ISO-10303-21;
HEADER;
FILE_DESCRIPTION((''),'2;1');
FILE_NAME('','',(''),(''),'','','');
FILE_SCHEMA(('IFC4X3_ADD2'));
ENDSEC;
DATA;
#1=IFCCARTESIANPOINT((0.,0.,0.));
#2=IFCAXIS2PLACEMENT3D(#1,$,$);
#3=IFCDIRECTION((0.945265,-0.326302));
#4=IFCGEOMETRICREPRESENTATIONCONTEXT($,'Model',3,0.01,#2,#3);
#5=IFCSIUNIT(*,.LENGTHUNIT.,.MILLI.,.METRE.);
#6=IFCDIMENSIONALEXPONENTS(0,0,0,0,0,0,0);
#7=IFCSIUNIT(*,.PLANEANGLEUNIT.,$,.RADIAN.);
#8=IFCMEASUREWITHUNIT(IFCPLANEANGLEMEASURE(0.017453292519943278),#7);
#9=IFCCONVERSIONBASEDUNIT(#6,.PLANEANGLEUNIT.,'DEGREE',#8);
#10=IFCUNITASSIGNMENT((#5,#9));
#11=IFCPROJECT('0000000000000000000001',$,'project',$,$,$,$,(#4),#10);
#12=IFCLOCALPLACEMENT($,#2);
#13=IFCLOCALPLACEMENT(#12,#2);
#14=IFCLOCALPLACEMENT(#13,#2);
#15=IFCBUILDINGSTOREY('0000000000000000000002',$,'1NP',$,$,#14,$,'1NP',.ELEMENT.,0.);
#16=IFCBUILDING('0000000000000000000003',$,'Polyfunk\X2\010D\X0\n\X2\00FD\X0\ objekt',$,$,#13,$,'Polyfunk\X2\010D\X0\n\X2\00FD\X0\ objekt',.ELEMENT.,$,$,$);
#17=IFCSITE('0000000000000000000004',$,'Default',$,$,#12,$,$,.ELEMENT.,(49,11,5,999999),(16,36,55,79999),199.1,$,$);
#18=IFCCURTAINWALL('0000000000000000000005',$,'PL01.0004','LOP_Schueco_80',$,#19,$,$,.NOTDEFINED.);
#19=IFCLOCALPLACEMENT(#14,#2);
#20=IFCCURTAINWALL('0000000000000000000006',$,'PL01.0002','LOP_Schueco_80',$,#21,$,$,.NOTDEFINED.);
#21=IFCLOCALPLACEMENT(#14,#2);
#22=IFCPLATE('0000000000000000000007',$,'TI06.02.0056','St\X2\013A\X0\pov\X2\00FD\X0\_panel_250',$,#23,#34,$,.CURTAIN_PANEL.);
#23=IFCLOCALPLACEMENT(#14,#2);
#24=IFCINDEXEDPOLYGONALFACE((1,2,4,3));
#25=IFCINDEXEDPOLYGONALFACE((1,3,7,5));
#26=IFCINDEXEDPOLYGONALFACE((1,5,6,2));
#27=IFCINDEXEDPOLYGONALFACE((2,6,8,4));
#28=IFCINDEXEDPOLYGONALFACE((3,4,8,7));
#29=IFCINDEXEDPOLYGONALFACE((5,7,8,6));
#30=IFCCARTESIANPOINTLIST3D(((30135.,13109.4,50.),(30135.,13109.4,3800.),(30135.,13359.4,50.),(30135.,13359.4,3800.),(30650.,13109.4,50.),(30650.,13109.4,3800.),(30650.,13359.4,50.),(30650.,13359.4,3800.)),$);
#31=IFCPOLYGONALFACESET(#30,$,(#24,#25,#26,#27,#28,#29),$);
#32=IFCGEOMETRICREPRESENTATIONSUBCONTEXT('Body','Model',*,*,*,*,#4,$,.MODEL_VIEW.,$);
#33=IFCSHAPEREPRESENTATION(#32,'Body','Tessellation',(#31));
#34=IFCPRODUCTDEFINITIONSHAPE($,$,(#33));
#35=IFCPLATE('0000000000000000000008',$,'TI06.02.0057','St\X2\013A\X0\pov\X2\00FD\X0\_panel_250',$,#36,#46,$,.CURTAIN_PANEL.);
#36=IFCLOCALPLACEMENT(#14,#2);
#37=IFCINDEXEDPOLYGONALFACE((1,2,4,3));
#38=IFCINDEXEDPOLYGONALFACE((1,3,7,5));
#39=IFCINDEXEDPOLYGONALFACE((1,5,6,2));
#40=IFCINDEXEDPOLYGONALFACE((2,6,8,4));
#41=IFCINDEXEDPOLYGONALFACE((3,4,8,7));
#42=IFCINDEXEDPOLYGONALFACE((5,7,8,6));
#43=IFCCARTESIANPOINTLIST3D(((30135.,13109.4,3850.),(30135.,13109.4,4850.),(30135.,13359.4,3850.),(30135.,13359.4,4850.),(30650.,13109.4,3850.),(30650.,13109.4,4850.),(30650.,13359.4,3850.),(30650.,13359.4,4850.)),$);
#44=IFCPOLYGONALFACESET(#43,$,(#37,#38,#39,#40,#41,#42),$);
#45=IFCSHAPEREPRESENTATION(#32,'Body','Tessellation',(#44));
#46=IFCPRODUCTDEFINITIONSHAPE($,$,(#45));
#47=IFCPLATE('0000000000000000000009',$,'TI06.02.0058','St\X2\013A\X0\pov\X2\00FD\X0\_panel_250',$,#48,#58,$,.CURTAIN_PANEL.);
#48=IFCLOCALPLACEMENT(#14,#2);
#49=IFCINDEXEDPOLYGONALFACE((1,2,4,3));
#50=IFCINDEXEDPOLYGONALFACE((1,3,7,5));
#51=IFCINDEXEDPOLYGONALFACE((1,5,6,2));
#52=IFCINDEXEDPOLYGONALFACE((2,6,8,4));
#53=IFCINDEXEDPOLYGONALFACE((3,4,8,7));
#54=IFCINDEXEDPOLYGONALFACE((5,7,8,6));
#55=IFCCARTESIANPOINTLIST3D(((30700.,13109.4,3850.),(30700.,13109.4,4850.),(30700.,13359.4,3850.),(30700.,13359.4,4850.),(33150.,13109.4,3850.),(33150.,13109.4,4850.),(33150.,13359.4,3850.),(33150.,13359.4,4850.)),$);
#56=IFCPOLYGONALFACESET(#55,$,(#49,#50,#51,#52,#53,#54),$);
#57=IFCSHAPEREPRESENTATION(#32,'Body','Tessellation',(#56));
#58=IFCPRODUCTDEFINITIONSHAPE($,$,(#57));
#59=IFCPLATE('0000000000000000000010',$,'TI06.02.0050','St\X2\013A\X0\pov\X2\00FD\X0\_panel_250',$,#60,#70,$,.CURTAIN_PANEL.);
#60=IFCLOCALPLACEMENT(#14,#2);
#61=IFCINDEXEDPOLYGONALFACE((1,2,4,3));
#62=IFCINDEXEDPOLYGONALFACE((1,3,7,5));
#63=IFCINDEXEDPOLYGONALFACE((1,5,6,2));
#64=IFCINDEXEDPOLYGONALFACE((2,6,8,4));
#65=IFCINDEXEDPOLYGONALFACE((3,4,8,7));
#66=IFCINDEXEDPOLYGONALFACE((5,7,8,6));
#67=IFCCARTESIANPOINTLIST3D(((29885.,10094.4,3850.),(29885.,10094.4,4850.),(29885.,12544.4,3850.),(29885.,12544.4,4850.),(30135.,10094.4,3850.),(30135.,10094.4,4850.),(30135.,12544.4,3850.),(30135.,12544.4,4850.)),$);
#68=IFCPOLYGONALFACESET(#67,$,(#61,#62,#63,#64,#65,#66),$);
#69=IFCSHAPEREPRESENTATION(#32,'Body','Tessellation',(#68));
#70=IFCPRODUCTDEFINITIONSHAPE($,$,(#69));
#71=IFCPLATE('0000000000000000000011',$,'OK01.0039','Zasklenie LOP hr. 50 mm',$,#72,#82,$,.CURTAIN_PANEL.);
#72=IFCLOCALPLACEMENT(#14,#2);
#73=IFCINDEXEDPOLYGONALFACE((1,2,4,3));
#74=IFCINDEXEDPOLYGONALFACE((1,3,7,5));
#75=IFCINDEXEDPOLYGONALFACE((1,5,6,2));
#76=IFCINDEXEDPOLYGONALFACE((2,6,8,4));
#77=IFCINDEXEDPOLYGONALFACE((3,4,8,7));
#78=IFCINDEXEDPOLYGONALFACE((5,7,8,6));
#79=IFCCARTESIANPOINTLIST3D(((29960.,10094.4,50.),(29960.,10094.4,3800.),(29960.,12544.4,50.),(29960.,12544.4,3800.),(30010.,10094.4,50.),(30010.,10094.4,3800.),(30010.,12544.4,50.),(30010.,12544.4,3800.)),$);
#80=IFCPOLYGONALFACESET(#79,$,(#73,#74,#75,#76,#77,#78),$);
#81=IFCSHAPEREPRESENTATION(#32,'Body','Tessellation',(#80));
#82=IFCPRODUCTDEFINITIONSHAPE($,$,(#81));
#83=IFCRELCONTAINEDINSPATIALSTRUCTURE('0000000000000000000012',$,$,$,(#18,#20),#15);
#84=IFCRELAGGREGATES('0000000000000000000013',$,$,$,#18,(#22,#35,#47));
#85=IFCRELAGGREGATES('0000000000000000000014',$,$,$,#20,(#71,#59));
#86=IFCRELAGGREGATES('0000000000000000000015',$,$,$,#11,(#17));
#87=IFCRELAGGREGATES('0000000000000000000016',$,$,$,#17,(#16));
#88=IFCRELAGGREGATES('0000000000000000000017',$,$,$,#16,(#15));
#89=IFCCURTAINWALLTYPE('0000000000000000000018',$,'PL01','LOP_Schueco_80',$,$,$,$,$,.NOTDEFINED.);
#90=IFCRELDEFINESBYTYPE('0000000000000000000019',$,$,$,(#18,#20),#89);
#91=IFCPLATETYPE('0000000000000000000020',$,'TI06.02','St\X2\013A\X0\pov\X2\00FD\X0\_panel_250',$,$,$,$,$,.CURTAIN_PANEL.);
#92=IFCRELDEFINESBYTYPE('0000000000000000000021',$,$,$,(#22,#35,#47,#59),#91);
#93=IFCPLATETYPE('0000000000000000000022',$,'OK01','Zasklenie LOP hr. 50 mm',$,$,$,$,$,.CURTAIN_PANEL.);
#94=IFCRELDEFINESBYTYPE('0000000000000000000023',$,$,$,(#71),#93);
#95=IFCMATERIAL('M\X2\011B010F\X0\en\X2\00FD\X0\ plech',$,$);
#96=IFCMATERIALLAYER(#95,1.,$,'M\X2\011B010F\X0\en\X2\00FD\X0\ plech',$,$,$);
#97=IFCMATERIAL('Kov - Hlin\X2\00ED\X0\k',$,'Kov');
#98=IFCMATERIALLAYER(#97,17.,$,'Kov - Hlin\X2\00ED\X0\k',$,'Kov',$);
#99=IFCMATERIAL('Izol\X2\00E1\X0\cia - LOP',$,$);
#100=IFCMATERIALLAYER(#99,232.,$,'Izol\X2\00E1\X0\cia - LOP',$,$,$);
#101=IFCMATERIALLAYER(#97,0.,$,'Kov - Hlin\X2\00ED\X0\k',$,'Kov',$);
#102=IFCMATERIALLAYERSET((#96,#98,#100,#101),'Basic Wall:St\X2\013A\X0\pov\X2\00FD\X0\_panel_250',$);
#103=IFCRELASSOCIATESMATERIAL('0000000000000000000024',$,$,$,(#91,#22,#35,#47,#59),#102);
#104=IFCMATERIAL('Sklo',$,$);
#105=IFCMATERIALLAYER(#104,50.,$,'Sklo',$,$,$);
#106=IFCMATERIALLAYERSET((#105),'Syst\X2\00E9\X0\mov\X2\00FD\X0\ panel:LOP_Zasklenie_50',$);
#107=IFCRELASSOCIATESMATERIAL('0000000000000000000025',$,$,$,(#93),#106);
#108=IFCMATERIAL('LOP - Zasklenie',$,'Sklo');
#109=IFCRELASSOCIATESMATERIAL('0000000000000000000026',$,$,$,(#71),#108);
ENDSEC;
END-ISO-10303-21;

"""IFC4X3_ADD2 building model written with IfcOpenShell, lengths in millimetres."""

from ifc_helpers import new_model, entity, si_unit, converted_unit, direction, frame, frame_2d, origin, place, context, subcontext, project, spatial, rectangle, extrude, source, transform, mapped, material, layer, layer_set, layer_usage, type_object, type_shapes, element, aggregate, save


model = new_model("IFC4X3_ADD2")

# Units and contexts
model_context = context("Model", 3, precision=0.01, world=origin(), true_north=direction((0.945265, -0.326302)))
body_context = subcontext(model_context, "Body", "Model", "MODEL_VIEW")
ifc_project = project(units=[si_unit("LENGTHUNIT", "METRE", prefix="MILLI"), converted_unit("PLANEANGLEUNIT", "DEGREE", entity("IfcPlaneAngleMeasure", 0.017453292519943278), si_unit("PLANEANGLEUNIT", "RADIAN"), dimensions=[0, 0, 0, 0, 0, 0, 0])], contexts=[model_context])

# Site, building, storey
site_placement = place(None, origin())
site = spatial("IfcSite", under=ifc_project, at=site_placement, Name="Default", CompositionType="ELEMENT", RefLatitude=(49, 11, 5, 999999), RefLongitude=(16, 36, 55, 79999), RefElevation=199.1)
building_placement = place(site_placement, origin())
building = spatial("IfcBuilding", under=site, at=building_placement, Name="Polyfunkčný objekt", LongName="Polyfunkčný objekt", CompositionType="ELEMENT")
storey_placement = place(building_placement, origin())
storey = spatial("IfcBuildingStorey", under=building, at=storey_placement, Name="1NP", LongName="1NP", CompositionType="ELEMENT", Elevation=0.0)

# Curtain walls
curtain_wall_type = type_object("IfcCurtainWallType", Name="PL01", Description="LOP_Schueco_80", PredefinedType="NOTDEFINED")
curtain_wall_1_placement = place(storey_placement, origin())
curtain_wall_1 = element("IfcCurtainWall", 1, at=curtain_wall_1_placement, inside=storey, type_object=curtain_wall_type, Name="PL01.0004", Description="LOP_Schueco_80", PredefinedType="NOTDEFINED")
curtain_wall_2_placement = place(storey_placement, origin())
curtain_wall_2 = element("IfcCurtainWall", 2, at=curtain_wall_2_placement, inside=storey, type_object=curtain_wall_type, Name="PL01.0002", Description="LOP_Schueco_80", PredefinedType="NOTDEFINED")

# Plates
ifc_material_1 = material(Name="Měďený plech")
ifc_layer_1 = layer(ifc_material_1, 1.0, Name="Měďený plech")
ifc_material_2 = material(Name="Kov - Hliník", Category="Kov")
ifc_layer_2 = layer(ifc_material_2, 17.0, Name="Kov - Hliník", Category="Kov")
ifc_material_3 = material(Name="Izolácia - LOP")
ifc_layer_3 = layer(ifc_material_3, 232.0, Name="Izolácia - LOP")
ifc_layer_4 = layer(ifc_material_2, 0.0, Name="Kov - Hliník", Category="Kov")
ifc_layer_set_1 = layer_set([ifc_layer_1, ifc_layer_2, ifc_layer_3, ifc_layer_4], Name="Basic Wall:Stĺpový_panel_250")
ifc_layer_usage_1 = layer_usage(ifc_layer_set_1, "AXIS2", "NEGATIVE", 125.0)
plate_type_1 = type_object("IfcPlateType", Name="TI06.02", Description="Stĺpový_panel_250", PredefinedType="CURTAIN_PANEL", material=ifc_layer_set_1)
plate_1_placement = place(storey_placement, frame((30135.0, 13234.4, 50.0)))
plate_1 = element("IfcPlate", 3, at=plate_1_placement, type_object=plate_type_1, material=ifc_layer_usage_1, Name="TI06.02.0056", Description="Stĺpový_panel_250", PredefinedType="CURTAIN_PANEL", context=body_context, shape_type="SweptSolid", body=[
    extrude(rectangle(XDim=250.0, YDim=515.0, at=frame_2d((0.0, 0.0), x_axis=(1.0, 0.0))), frame((257.5, 0.0, 0.0), z_axis=(0.0, 0.0, 1.0), x_axis=(0.0, 1.0, 0.0)), (0.0, 0.0, 1.0), 3750.0),
])
ifc_layer_usage_2 = layer_usage(ifc_layer_set_1, "AXIS2", "NEGATIVE", 125.0)
plate_2_placement = place(storey_placement, frame((30135.0, 13234.4, 3850.0)))
plate_2 = element("IfcPlate", 4, at=plate_2_placement, type_object=plate_type_1, material=ifc_layer_usage_2, Name="TI06.02.0057", Description="Stĺpový_panel_250", PredefinedType="CURTAIN_PANEL", context=body_context, shape_type="SweptSolid", body=[
    extrude(rectangle(XDim=250.0, YDim=515.0, at=frame_2d((0.0, 0.0), x_axis=(1.0, 0.0))), frame((257.5, 0.0, 0.0), z_axis=(0.0, 0.0, 1.0), x_axis=(0.0, 1.0, 0.0)), (0.0, 0.0, 1.0), 1000.0),
])
ifc_layer_usage_3 = layer_usage(ifc_layer_set_1, "AXIS2", "NEGATIVE", 125.0)
plate_3_placement = place(storey_placement, frame((30700.0, 13234.4, 3850.0)))
plate_3 = element("IfcPlate", 5, at=plate_3_placement, type_object=plate_type_1, material=ifc_layer_usage_3, Name="TI06.02.0058", Description="Stĺpový_panel_250", PredefinedType="CURTAIN_PANEL", context=body_context, shape_type="SweptSolid", body=[
    extrude(rectangle(XDim=250.0, YDim=2450.0, at=frame_2d((0.0, 0.0), x_axis=(1.0, 0.0))), frame((1225.0, 0.0, 0.0), z_axis=(0.0, 0.0, 1.0), x_axis=(0.0, 1.0, 0.0)), (0.0, 0.0, 1.0), 1000.0),
])
aggregate(curtain_wall_1, [plate_1, plate_2, plate_3])
ifc_layer_usage_4 = layer_usage(ifc_layer_set_1, "AXIS2", "POSITIVE", -125.0)
plate_4_placement = place(storey_placement, frame((30010.0, 12544.4, 3850.0), z_axis=(0.0, 0.0, 1.0), x_axis=(0.0, -1.0, 0.0)))
plate_4 = element("IfcPlate", 6, at=plate_4_placement, type_object=plate_type_1, material=ifc_layer_usage_4, Name="TI06.02.0050", Description="Stĺpový_panel_250", PredefinedType="CURTAIN_PANEL", context=body_context, shape_type="SweptSolid", body=[
    extrude(rectangle(XDim=250.0, YDim=2450.0, at=frame_2d((0.0, 0.0), x_axis=(1.0, 0.0))), frame((1225.0, 0.0, 0.0), z_axis=(0.0, 0.0, 1.0), x_axis=(0.0, 1.0, 0.0)), (0.0, 0.0, 1.0), 1000.0),
])
ifc_material_4 = material(Name="LOP - Zasklenie", Category="Sklo")
ifc_material_5 = material(Name="Sklo")
ifc_layer_5 = layer(ifc_material_5, 50.0, Name="Sklo")
ifc_layer_set_2 = layer_set([ifc_layer_5], Name="Systémový panel:LOP_Zasklenie_50")
plate_type_2 = type_object("IfcPlateType", Name="OK01", Description="Zasklenie LOP hr. 50 mm", PredefinedType="CURTAIN_PANEL", material=ifc_layer_set_2)
shared_shape_1 = source(origin(), body_context, "Body", "SweptSolid", [
    extrude(rectangle(XDim=3750.0, YDim=2450.0, at=frame_2d((-141.7, 0.0), x_axis=(1.0, 0.0))), frame((0.0, -50.0, 2016.7), z_axis=(0.0, 1.0, 0.0), x_axis=(0.0, 0.0, 1.0)), (0.0, 0.0, 1.0), 50.0),
])
type_shapes(plate_type_2, [shared_shape_1])
plate_5_placement = place(curtain_wall_2_placement, frame((30010.0, 11319.4, 50.0), z_axis=(0.0, 0.0, 1.0), x_axis=(0.0, -1.0, 0.0)))
plate_5 = element("IfcPlate", 7, at=plate_5_placement, type_object=plate_type_2, material=ifc_material_4, Name="OK01.0039", Description="Zasklenie LOP hr. 50 mm", PredefinedType="CURTAIN_PANEL", context=body_context, shape_type="MappedRepresentation", body=[
    mapped(shared_shape_1, transform((0.0, 0.0, 0.0), scale=1.0)),
])
aggregate(curtain_wall_2, [plate_5, plate_4])

save(model, "model.ifc")
